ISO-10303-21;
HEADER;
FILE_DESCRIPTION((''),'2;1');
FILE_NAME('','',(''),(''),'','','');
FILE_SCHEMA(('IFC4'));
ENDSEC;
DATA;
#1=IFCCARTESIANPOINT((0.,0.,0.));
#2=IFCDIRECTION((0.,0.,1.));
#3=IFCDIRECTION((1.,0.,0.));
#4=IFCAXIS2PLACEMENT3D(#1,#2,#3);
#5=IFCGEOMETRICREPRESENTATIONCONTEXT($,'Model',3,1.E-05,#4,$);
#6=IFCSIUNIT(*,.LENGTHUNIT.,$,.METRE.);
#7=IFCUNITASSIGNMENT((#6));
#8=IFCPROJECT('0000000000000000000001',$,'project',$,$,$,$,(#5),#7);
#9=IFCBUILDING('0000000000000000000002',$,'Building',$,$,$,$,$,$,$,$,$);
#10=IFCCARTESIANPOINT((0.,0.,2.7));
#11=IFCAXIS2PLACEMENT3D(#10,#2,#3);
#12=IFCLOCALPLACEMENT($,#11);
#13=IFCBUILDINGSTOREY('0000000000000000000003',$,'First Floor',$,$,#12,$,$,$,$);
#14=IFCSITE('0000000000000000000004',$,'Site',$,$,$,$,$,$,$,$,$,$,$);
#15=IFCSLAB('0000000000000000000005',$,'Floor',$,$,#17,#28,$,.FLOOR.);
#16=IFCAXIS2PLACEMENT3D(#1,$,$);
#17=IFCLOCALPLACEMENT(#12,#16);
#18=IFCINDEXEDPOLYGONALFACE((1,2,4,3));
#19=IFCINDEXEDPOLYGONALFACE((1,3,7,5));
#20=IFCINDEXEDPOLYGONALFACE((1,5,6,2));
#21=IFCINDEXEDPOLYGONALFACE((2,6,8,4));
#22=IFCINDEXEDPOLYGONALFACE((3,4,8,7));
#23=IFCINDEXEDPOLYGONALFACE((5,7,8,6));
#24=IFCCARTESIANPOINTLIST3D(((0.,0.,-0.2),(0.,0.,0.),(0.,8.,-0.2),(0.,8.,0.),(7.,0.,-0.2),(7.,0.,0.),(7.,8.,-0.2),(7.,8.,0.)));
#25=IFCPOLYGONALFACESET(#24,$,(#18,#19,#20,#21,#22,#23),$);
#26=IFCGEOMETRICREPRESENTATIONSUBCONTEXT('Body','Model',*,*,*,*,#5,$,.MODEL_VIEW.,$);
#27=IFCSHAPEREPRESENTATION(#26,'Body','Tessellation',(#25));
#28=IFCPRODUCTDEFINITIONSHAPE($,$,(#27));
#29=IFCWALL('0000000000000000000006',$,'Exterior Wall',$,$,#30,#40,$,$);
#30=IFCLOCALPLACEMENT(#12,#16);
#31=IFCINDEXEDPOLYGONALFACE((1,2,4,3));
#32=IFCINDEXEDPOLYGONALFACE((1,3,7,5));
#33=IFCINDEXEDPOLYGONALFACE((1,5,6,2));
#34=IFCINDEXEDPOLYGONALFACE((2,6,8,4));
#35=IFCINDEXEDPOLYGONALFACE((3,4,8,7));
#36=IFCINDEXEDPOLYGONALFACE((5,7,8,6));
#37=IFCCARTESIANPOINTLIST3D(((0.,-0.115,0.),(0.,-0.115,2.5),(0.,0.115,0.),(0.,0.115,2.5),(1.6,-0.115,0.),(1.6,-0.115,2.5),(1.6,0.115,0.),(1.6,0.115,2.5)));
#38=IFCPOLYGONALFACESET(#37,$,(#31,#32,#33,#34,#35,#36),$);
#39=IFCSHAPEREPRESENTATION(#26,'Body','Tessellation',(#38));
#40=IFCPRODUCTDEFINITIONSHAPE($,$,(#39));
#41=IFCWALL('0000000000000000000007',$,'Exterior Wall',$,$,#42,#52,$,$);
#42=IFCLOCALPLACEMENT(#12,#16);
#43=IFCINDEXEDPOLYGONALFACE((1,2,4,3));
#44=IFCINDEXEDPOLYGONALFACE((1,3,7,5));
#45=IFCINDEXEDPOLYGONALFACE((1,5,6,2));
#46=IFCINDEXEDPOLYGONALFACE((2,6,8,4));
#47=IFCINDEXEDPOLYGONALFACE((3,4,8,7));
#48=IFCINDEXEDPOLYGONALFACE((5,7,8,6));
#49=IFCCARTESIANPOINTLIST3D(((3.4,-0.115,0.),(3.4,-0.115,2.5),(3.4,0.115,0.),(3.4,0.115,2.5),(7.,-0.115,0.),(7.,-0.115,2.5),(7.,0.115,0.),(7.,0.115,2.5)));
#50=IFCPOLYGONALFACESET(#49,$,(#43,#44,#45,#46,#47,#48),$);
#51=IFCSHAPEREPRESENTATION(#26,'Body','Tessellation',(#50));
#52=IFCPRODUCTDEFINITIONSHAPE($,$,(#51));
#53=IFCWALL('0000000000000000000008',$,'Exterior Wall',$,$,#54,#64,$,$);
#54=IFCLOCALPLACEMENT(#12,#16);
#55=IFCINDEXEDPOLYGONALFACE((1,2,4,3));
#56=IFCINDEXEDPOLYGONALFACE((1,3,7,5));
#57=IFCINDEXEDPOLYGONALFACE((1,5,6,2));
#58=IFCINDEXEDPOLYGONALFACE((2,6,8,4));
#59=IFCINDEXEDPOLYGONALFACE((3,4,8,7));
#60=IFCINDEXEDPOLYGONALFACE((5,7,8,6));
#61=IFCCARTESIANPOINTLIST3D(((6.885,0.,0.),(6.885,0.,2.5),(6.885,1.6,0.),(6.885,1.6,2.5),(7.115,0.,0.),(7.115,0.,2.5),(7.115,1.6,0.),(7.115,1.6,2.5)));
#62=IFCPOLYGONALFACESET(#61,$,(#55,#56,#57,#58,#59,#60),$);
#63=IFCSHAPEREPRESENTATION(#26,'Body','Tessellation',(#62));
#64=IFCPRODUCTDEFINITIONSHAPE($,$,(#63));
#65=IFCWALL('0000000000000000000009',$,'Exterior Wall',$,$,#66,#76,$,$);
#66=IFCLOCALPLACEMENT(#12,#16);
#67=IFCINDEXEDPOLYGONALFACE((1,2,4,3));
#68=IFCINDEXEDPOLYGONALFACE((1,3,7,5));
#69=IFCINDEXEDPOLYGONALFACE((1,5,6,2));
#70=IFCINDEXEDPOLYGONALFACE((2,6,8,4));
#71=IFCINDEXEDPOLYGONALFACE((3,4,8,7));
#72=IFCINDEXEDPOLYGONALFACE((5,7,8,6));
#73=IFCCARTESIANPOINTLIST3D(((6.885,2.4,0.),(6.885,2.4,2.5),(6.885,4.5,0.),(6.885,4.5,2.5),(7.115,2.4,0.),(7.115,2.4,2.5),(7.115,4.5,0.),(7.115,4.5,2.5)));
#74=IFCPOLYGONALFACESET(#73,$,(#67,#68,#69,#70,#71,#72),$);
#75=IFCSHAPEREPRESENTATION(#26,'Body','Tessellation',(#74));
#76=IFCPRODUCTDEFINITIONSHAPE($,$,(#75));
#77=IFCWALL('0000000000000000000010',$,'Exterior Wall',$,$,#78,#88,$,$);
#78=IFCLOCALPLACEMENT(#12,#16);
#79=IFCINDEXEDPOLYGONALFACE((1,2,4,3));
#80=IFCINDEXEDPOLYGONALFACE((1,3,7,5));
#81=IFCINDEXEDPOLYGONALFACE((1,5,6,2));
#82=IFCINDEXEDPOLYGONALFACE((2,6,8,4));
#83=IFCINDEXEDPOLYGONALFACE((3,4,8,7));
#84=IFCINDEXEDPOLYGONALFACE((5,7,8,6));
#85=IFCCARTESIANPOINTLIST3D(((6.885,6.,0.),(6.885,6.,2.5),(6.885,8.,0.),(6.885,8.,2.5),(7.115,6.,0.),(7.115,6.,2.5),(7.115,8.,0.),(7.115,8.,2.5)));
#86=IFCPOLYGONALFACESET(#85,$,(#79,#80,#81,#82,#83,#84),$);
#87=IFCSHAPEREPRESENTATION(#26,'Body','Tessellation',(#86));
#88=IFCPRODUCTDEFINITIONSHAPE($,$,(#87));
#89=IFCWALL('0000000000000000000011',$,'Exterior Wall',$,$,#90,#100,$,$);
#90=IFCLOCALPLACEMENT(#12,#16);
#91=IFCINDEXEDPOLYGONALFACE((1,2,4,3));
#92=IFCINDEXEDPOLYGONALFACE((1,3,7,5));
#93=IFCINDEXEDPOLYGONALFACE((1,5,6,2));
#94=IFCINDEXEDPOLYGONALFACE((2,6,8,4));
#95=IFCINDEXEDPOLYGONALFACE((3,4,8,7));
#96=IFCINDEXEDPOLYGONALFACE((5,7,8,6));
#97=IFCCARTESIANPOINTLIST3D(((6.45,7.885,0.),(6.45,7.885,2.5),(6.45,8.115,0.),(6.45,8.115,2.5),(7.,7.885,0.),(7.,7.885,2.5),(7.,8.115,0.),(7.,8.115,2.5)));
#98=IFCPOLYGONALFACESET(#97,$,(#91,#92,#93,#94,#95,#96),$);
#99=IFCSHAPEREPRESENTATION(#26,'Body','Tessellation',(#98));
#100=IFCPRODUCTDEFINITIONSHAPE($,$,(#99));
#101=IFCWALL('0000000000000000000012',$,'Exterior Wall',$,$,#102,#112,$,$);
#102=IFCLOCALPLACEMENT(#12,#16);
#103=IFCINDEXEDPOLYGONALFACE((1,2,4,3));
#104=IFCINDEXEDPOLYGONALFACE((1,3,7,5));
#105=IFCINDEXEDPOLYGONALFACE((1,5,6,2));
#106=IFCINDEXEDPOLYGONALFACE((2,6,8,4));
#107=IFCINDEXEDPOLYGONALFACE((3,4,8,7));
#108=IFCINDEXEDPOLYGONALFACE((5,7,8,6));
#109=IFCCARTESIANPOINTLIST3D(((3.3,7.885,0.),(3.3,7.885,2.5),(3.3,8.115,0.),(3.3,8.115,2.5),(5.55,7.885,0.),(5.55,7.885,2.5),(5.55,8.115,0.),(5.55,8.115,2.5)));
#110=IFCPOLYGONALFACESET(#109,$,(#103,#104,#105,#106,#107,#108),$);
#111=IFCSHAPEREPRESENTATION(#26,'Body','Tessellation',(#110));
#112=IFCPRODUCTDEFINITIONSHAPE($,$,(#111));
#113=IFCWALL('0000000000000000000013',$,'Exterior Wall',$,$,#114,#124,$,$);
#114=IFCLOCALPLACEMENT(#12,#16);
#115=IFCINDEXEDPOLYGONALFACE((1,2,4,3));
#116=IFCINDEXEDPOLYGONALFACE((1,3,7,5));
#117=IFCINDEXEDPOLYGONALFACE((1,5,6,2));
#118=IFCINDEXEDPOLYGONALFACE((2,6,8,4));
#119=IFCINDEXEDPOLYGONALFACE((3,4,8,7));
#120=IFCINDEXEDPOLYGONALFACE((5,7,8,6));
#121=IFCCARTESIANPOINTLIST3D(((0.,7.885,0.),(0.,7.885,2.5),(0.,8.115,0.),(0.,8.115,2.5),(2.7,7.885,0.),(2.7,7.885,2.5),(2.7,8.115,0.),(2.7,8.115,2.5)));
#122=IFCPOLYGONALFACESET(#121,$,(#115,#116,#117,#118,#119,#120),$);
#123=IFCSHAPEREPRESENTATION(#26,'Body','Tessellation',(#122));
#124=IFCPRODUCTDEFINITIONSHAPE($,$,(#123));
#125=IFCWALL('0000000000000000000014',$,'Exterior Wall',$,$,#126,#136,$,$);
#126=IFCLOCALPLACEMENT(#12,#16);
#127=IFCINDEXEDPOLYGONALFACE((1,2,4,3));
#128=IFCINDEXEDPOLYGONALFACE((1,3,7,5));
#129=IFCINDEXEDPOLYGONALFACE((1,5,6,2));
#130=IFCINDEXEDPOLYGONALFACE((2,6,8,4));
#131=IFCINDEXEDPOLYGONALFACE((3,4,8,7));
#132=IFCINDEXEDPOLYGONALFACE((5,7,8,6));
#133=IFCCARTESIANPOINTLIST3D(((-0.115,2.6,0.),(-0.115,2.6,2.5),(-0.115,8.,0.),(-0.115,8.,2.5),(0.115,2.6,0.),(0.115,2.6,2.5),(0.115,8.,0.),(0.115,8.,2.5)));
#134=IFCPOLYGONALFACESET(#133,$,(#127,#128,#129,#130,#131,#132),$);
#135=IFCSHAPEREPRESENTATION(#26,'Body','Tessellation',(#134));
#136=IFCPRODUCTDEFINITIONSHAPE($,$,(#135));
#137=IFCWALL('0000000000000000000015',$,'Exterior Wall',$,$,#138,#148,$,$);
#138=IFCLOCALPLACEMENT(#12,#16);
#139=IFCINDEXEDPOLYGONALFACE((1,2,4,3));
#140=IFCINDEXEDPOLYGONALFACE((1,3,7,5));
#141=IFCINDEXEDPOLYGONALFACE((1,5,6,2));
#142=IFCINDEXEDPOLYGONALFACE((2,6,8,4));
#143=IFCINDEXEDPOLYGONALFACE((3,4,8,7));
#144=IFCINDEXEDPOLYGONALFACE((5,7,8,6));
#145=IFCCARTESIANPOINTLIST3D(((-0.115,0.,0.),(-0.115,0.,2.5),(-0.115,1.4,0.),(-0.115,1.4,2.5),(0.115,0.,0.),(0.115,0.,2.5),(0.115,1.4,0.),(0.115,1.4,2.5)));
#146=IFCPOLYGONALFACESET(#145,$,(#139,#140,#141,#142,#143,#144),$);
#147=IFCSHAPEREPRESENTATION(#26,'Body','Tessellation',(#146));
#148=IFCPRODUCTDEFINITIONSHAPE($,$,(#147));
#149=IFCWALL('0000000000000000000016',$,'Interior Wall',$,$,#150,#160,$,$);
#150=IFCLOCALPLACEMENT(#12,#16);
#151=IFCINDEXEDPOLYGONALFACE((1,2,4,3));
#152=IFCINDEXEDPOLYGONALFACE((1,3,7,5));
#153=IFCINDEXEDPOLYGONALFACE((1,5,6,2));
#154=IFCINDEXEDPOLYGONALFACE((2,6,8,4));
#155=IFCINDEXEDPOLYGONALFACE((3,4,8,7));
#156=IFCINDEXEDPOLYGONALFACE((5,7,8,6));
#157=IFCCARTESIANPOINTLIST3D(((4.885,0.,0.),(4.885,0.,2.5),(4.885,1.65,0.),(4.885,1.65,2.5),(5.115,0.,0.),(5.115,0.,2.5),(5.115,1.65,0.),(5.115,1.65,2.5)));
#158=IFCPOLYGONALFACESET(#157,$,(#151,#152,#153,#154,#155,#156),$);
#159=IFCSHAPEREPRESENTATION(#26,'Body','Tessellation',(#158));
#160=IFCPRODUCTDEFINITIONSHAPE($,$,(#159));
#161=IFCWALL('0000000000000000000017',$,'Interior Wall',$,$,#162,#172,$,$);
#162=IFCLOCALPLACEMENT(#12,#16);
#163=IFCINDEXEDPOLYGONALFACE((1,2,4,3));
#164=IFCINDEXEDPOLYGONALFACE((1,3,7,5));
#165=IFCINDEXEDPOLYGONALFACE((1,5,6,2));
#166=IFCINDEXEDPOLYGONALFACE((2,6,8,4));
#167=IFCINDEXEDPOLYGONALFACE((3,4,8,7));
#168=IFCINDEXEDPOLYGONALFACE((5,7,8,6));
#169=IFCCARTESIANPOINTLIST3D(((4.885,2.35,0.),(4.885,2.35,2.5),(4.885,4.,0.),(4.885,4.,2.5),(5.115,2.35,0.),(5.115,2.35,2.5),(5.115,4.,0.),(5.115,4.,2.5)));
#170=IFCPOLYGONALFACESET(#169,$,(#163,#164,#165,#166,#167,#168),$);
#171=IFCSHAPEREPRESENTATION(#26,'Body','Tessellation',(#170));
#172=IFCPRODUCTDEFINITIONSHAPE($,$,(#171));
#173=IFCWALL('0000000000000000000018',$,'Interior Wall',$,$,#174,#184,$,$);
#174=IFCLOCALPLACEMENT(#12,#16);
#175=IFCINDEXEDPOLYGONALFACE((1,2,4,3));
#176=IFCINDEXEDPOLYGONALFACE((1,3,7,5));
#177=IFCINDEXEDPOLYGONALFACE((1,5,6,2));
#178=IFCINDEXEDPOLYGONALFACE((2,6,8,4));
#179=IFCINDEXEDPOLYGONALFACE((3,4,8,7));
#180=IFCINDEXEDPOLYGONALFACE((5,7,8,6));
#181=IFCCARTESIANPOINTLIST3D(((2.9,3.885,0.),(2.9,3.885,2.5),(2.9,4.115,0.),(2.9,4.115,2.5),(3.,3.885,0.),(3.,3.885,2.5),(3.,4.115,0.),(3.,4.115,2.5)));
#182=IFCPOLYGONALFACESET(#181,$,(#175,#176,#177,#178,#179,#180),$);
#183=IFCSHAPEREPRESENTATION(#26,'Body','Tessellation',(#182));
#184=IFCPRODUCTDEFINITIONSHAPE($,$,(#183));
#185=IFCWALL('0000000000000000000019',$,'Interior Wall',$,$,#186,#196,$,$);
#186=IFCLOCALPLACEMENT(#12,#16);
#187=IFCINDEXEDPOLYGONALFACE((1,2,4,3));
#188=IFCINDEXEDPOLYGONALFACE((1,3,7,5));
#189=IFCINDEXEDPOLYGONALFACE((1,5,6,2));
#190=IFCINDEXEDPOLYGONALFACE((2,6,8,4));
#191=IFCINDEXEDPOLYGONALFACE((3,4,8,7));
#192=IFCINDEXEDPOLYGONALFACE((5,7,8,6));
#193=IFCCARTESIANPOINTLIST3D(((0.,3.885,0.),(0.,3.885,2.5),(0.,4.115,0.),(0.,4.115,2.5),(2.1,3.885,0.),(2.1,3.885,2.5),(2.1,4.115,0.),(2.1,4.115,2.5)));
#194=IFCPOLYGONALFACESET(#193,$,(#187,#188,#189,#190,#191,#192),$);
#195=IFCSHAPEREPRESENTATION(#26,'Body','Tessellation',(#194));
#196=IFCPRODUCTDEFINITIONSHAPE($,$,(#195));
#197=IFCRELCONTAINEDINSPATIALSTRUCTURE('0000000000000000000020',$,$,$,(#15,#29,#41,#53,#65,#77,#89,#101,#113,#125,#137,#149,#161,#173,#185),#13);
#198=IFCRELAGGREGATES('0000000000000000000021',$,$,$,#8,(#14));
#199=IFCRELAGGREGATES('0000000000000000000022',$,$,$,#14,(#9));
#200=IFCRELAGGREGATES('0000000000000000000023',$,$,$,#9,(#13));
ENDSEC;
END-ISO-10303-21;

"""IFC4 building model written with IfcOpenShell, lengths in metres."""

from ifc_helpers import new_model, si_unit, frame, origin_with_axes, place, context, subcontext, project, spatial, indexed_curve, outline, extrude, element, save


model = new_model("IFC4")

# Units and contexts
model_context = context("Model", 3, precision=1e-05, world=origin_with_axes())
body_context = subcontext(model_context, "Body", "Model", "MODEL_VIEW")
ifc_project = project(units=[si_unit("LENGTHUNIT", "METRE")], contexts=[model_context])

# Site, building, storey
site = spatial("IfcSite", under=ifc_project, Name="Site")
building = spatial("IfcBuilding", under=site, Name="Building")
storey_placement = place(None, frame((0.0, 0.0, 2.7), z_axis=(0.0, 0.0, 1.0), x_axis=(1.0, 0.0, 0.0)))
storey = spatial("IfcBuildingStorey", under=building, at=storey_placement, Name="First Floor")

# Slab
slab_placement = place(storey_placement, frame((0.0, 0.0, -0.2), z_axis=(0.0, 0.0, 1.0), x_axis=(1.0, 0.0, 0.0)))
element("IfcSlab", 1, at=slab_placement, inside=storey, Name="Floor", PredefinedType="FLOOR", context=body_context, shape_type="SweptSolid", body=[
    extrude(outline(indexed_curve([(0.0, 0.0), (7.0, 0.0), (7.0, 8.0), (0.0, 8.0)])), None, (0.0, 0.0, 1.0), 0.2),
])

# Walls
wall_1_placement = place(storey_placement, origin_with_axes())
element("IfcWall", 2, at=wall_1_placement, inside=storey, Name="Exterior Wall", context=body_context, shape_type="SweptSolid", body=[
    extrude(outline(indexed_curve([(0.0, 0.0), (0.0, 0.23), (1.6, 0.23), (1.6, 0.0), (0.0, 0.0)], self_intersect=False)), frame((0.0, -0.115, 0.0), z_axis=(0.0, 0.0, 1.0), x_axis=(1.0, 0.0, 0.0)), (0.0, 0.0, 1.0), 2.5),
])
wall_2_placement = place(storey_placement, frame((3.4, 0.0, 0.0), z_axis=(0.0, 0.0, 1.0), x_axis=(1.0, 0.0, 0.0)))
element("IfcWall", 3, at=wall_2_placement, inside=storey, Name="Exterior Wall", context=body_context, shape_type="SweptSolid", body=[
    extrude(outline(indexed_curve([(0.0, 0.0), (0.0, 0.23), (3.6, 0.23), (3.6, 0.0), (0.0, 0.0)], self_intersect=False)), frame((0.0, -0.115, 0.0), z_axis=(0.0, 0.0, 1.0), x_axis=(1.0, 0.0, 0.0)), (0.0, 0.0, 1.0), 2.5),
])
wall_3_placement = place(storey_placement, frame((7.0, 0.0, 0.0), z_axis=(0.0, 0.0, 1.0), x_axis=(0.0, 1.0, 0.0)))
element("IfcWall", 4, at=wall_3_placement, inside=storey, Name="Exterior Wall", context=body_context, shape_type="SweptSolid", body=[
    extrude(outline(indexed_curve([(0.0, 0.0), (0.0, 0.23), (1.6, 0.23), (1.6, 0.0), (0.0, 0.0)], self_intersect=False)), frame((0.0, -0.115, 0.0), z_axis=(0.0, 0.0, 1.0), x_axis=(1.0, 0.0, 0.0)), (0.0, 0.0, 1.0), 2.5),
])
wall_4_placement = place(storey_placement, frame((7.0, 2.4, 0.0), z_axis=(0.0, 0.0, 1.0), x_axis=(0.0, 1.0, 0.0)))
element("IfcWall", 5, at=wall_4_placement, inside=storey, Name="Exterior Wall", context=body_context, shape_type="SweptSolid", body=[
    extrude(outline(indexed_curve([(0.0, 0.0), (0.0, 0.23), (2.1, 0.23), (2.1, 0.0), (0.0, 0.0)], self_intersect=False)), frame((0.0, -0.115, 0.0), z_axis=(0.0, 0.0, 1.0), x_axis=(1.0, 0.0, 0.0)), (0.0, 0.0, 1.0), 2.5),
])
wall_5_placement = place(storey_placement, frame((7.0, 6.0, 0.0), z_axis=(0.0, 0.0, 1.0), x_axis=(0.0, 1.0, 0.0)))
element("IfcWall", 6, at=wall_5_placement, inside=storey, Name="Exterior Wall", context=body_context, shape_type="SweptSolid", body=[
    extrude(outline(indexed_curve([(0.0, 0.0), (0.0, 0.23), (2.0, 0.23), (2.0, 0.0), (0.0, 0.0)], self_intersect=False)), frame((0.0, -0.115, 0.0), z_axis=(0.0, 0.0, 1.0), x_axis=(1.0, 0.0, 0.0)), (0.0, 0.0, 1.0), 2.5),
])
wall_6_placement = place(storey_placement, frame((7.0, 8.0, 0.0), z_axis=(0.0, 0.0, 1.0), x_axis=(-1.0, 0.0, 0.0)))
element("IfcWall", 7, at=wall_6_placement, inside=storey, Name="Exterior Wall", context=body_context, shape_type="SweptSolid", body=[
    extrude(outline(indexed_curve([(0.0, 0.0), (0.0, 0.23), (0.55, 0.23), (0.55, 0.0), (0.0, 0.0)], self_intersect=False)), frame((0.0, -0.115, 0.0), z_axis=(0.0, 0.0, 1.0), x_axis=(1.0, 0.0, 0.0)), (0.0, 0.0, 1.0), 2.5),
])
wall_7_placement = place(storey_placement, frame((5.55, 8.0, 0.0), z_axis=(0.0, 0.0, 1.0), x_axis=(-1.0, 0.0, 0.0)))
element("IfcWall", 8, at=wall_7_placement, inside=storey, Name="Exterior Wall", context=body_context, shape_type="SweptSolid", body=[
    extrude(outline(indexed_curve([(0.0, 0.0), (0.0, 0.23), (2.25, 0.23), (2.25, 0.0), (0.0, 0.0)], self_intersect=False)), frame((0.0, -0.115, 0.0), z_axis=(0.0, 0.0, 1.0), x_axis=(1.0, 0.0, 0.0)), (0.0, 0.0, 1.0), 2.5),
])
wall_8_placement = place(storey_placement, frame((2.7, 8.0, 0.0), z_axis=(0.0, 0.0, 1.0), x_axis=(-1.0, 0.0, 0.0)))
element("IfcWall", 9, at=wall_8_placement, inside=storey, Name="Exterior Wall", context=body_context, shape_type="SweptSolid", body=[
    extrude(outline(indexed_curve([(0.0, 0.0), (0.0, 0.23), (2.7, 0.23), (2.7, 0.0), (0.0, 0.0)], self_intersect=False)), frame((0.0, -0.115, 0.0), z_axis=(0.0, 0.0, 1.0), x_axis=(1.0, 0.0, 0.0)), (0.0, 0.0, 1.0), 2.5),
])
wall_9_placement = place(storey_placement, frame((0.0, 8.0, 0.0), z_axis=(0.0, 0.0, 1.0), x_axis=(0.0, -1.0, 0.0)))
element("IfcWall", 10, at=wall_9_placement, inside=storey, Name="Exterior Wall", context=body_context, shape_type="SweptSolid", body=[
    extrude(outline(indexed_curve([(0.0, 0.0), (0.0, 0.23), (5.4, 0.23), (5.4, 0.0), (0.0, 0.0)], self_intersect=False)), frame((0.0, -0.115, 0.0), z_axis=(0.0, 0.0, 1.0), x_axis=(1.0, 0.0, 0.0)), (0.0, 0.0, 1.0), 2.5),
])
wall_10_placement = place(storey_placement, frame((0.0, 1.4, 0.0), z_axis=(0.0, 0.0, 1.0), x_axis=(0.0, -1.0, 0.0)))
element("IfcWall", 11, at=wall_10_placement, inside=storey, Name="Exterior Wall", context=body_context, shape_type="SweptSolid", body=[
    extrude(outline(indexed_curve([(0.0, 0.0), (0.0, 0.23), (1.4, 0.23), (1.4, 0.0), (0.0, 0.0)], self_intersect=False)), frame((0.0, -0.115, 0.0), z_axis=(0.0, 0.0, 1.0), x_axis=(1.0, 0.0, 0.0)), (0.0, 0.0, 1.0), 2.5),
])
for number, where, z_axis, x_axis, name in (
    (12, (5.0, 0.0, 0.0), (0.0, 0.0, 1.0), (0.0, 1.0, 0.0), "Interior Wall"),
    (13, (5.0, 2.35, 0.0), (0.0, 0.0, 1.0), (0.0, 1.0, 0.0), "Interior Wall"),
):
    element("IfcWall", number, at=place(storey_placement, frame(where, z_axis=z_axis, x_axis=x_axis)), inside=storey, Name=name, context=body_context, shape_type="SweptSolid", body=[
        extrude(outline(indexed_curve([(0.0, 0.0), (0.0, 0.23), (1.65, 0.23), (1.65, 0.0), (0.0, 0.0)], self_intersect=False)), frame((0.0, -0.115, 0.0), z_axis=(0.0, 0.0, 1.0), x_axis=(1.0, 0.0, 0.0)), (0.0, 0.0, 1.0), 2.5),
    ])
wall_11_placement = place(storey_placement, frame((3.0, 4.0, 0.0), z_axis=(0.0, 0.0, 1.0), x_axis=(-1.0, 0.0, 0.0)))
element("IfcWall", 14, at=wall_11_placement, inside=storey, Name="Interior Wall", context=body_context, shape_type="SweptSolid", body=[
    extrude(outline(indexed_curve([(0.0, 0.0), (0.0, 0.23), (0.1, 0.23), (0.1, 0.0), (0.0, 0.0)], self_intersect=False)), frame((0.0, -0.115, 0.0), z_axis=(0.0, 0.0, 1.0), x_axis=(1.0, 0.0, 0.0)), (0.0, 0.0, 1.0), 2.5),
])
wall_12_placement = place(storey_placement, frame((2.1, 4.0, 0.0), z_axis=(0.0, 0.0, 1.0), x_axis=(-1.0, 0.0, 0.0)))
element("IfcWall", 15, at=wall_12_placement, inside=storey, Name="Interior Wall", context=body_context, shape_type="SweptSolid", body=[
    extrude(outline(indexed_curve([(0.0, 0.0), (0.0, 0.23), (2.1, 0.23), (2.1, 0.0), (0.0, 0.0)], self_intersect=False)), frame((0.0, -0.115, 0.0), z_axis=(0.0, 0.0, 1.0), x_axis=(1.0, 0.0, 0.0)), (0.0, 0.0, 1.0), 2.5),
])

save(model, "model.ifc")
